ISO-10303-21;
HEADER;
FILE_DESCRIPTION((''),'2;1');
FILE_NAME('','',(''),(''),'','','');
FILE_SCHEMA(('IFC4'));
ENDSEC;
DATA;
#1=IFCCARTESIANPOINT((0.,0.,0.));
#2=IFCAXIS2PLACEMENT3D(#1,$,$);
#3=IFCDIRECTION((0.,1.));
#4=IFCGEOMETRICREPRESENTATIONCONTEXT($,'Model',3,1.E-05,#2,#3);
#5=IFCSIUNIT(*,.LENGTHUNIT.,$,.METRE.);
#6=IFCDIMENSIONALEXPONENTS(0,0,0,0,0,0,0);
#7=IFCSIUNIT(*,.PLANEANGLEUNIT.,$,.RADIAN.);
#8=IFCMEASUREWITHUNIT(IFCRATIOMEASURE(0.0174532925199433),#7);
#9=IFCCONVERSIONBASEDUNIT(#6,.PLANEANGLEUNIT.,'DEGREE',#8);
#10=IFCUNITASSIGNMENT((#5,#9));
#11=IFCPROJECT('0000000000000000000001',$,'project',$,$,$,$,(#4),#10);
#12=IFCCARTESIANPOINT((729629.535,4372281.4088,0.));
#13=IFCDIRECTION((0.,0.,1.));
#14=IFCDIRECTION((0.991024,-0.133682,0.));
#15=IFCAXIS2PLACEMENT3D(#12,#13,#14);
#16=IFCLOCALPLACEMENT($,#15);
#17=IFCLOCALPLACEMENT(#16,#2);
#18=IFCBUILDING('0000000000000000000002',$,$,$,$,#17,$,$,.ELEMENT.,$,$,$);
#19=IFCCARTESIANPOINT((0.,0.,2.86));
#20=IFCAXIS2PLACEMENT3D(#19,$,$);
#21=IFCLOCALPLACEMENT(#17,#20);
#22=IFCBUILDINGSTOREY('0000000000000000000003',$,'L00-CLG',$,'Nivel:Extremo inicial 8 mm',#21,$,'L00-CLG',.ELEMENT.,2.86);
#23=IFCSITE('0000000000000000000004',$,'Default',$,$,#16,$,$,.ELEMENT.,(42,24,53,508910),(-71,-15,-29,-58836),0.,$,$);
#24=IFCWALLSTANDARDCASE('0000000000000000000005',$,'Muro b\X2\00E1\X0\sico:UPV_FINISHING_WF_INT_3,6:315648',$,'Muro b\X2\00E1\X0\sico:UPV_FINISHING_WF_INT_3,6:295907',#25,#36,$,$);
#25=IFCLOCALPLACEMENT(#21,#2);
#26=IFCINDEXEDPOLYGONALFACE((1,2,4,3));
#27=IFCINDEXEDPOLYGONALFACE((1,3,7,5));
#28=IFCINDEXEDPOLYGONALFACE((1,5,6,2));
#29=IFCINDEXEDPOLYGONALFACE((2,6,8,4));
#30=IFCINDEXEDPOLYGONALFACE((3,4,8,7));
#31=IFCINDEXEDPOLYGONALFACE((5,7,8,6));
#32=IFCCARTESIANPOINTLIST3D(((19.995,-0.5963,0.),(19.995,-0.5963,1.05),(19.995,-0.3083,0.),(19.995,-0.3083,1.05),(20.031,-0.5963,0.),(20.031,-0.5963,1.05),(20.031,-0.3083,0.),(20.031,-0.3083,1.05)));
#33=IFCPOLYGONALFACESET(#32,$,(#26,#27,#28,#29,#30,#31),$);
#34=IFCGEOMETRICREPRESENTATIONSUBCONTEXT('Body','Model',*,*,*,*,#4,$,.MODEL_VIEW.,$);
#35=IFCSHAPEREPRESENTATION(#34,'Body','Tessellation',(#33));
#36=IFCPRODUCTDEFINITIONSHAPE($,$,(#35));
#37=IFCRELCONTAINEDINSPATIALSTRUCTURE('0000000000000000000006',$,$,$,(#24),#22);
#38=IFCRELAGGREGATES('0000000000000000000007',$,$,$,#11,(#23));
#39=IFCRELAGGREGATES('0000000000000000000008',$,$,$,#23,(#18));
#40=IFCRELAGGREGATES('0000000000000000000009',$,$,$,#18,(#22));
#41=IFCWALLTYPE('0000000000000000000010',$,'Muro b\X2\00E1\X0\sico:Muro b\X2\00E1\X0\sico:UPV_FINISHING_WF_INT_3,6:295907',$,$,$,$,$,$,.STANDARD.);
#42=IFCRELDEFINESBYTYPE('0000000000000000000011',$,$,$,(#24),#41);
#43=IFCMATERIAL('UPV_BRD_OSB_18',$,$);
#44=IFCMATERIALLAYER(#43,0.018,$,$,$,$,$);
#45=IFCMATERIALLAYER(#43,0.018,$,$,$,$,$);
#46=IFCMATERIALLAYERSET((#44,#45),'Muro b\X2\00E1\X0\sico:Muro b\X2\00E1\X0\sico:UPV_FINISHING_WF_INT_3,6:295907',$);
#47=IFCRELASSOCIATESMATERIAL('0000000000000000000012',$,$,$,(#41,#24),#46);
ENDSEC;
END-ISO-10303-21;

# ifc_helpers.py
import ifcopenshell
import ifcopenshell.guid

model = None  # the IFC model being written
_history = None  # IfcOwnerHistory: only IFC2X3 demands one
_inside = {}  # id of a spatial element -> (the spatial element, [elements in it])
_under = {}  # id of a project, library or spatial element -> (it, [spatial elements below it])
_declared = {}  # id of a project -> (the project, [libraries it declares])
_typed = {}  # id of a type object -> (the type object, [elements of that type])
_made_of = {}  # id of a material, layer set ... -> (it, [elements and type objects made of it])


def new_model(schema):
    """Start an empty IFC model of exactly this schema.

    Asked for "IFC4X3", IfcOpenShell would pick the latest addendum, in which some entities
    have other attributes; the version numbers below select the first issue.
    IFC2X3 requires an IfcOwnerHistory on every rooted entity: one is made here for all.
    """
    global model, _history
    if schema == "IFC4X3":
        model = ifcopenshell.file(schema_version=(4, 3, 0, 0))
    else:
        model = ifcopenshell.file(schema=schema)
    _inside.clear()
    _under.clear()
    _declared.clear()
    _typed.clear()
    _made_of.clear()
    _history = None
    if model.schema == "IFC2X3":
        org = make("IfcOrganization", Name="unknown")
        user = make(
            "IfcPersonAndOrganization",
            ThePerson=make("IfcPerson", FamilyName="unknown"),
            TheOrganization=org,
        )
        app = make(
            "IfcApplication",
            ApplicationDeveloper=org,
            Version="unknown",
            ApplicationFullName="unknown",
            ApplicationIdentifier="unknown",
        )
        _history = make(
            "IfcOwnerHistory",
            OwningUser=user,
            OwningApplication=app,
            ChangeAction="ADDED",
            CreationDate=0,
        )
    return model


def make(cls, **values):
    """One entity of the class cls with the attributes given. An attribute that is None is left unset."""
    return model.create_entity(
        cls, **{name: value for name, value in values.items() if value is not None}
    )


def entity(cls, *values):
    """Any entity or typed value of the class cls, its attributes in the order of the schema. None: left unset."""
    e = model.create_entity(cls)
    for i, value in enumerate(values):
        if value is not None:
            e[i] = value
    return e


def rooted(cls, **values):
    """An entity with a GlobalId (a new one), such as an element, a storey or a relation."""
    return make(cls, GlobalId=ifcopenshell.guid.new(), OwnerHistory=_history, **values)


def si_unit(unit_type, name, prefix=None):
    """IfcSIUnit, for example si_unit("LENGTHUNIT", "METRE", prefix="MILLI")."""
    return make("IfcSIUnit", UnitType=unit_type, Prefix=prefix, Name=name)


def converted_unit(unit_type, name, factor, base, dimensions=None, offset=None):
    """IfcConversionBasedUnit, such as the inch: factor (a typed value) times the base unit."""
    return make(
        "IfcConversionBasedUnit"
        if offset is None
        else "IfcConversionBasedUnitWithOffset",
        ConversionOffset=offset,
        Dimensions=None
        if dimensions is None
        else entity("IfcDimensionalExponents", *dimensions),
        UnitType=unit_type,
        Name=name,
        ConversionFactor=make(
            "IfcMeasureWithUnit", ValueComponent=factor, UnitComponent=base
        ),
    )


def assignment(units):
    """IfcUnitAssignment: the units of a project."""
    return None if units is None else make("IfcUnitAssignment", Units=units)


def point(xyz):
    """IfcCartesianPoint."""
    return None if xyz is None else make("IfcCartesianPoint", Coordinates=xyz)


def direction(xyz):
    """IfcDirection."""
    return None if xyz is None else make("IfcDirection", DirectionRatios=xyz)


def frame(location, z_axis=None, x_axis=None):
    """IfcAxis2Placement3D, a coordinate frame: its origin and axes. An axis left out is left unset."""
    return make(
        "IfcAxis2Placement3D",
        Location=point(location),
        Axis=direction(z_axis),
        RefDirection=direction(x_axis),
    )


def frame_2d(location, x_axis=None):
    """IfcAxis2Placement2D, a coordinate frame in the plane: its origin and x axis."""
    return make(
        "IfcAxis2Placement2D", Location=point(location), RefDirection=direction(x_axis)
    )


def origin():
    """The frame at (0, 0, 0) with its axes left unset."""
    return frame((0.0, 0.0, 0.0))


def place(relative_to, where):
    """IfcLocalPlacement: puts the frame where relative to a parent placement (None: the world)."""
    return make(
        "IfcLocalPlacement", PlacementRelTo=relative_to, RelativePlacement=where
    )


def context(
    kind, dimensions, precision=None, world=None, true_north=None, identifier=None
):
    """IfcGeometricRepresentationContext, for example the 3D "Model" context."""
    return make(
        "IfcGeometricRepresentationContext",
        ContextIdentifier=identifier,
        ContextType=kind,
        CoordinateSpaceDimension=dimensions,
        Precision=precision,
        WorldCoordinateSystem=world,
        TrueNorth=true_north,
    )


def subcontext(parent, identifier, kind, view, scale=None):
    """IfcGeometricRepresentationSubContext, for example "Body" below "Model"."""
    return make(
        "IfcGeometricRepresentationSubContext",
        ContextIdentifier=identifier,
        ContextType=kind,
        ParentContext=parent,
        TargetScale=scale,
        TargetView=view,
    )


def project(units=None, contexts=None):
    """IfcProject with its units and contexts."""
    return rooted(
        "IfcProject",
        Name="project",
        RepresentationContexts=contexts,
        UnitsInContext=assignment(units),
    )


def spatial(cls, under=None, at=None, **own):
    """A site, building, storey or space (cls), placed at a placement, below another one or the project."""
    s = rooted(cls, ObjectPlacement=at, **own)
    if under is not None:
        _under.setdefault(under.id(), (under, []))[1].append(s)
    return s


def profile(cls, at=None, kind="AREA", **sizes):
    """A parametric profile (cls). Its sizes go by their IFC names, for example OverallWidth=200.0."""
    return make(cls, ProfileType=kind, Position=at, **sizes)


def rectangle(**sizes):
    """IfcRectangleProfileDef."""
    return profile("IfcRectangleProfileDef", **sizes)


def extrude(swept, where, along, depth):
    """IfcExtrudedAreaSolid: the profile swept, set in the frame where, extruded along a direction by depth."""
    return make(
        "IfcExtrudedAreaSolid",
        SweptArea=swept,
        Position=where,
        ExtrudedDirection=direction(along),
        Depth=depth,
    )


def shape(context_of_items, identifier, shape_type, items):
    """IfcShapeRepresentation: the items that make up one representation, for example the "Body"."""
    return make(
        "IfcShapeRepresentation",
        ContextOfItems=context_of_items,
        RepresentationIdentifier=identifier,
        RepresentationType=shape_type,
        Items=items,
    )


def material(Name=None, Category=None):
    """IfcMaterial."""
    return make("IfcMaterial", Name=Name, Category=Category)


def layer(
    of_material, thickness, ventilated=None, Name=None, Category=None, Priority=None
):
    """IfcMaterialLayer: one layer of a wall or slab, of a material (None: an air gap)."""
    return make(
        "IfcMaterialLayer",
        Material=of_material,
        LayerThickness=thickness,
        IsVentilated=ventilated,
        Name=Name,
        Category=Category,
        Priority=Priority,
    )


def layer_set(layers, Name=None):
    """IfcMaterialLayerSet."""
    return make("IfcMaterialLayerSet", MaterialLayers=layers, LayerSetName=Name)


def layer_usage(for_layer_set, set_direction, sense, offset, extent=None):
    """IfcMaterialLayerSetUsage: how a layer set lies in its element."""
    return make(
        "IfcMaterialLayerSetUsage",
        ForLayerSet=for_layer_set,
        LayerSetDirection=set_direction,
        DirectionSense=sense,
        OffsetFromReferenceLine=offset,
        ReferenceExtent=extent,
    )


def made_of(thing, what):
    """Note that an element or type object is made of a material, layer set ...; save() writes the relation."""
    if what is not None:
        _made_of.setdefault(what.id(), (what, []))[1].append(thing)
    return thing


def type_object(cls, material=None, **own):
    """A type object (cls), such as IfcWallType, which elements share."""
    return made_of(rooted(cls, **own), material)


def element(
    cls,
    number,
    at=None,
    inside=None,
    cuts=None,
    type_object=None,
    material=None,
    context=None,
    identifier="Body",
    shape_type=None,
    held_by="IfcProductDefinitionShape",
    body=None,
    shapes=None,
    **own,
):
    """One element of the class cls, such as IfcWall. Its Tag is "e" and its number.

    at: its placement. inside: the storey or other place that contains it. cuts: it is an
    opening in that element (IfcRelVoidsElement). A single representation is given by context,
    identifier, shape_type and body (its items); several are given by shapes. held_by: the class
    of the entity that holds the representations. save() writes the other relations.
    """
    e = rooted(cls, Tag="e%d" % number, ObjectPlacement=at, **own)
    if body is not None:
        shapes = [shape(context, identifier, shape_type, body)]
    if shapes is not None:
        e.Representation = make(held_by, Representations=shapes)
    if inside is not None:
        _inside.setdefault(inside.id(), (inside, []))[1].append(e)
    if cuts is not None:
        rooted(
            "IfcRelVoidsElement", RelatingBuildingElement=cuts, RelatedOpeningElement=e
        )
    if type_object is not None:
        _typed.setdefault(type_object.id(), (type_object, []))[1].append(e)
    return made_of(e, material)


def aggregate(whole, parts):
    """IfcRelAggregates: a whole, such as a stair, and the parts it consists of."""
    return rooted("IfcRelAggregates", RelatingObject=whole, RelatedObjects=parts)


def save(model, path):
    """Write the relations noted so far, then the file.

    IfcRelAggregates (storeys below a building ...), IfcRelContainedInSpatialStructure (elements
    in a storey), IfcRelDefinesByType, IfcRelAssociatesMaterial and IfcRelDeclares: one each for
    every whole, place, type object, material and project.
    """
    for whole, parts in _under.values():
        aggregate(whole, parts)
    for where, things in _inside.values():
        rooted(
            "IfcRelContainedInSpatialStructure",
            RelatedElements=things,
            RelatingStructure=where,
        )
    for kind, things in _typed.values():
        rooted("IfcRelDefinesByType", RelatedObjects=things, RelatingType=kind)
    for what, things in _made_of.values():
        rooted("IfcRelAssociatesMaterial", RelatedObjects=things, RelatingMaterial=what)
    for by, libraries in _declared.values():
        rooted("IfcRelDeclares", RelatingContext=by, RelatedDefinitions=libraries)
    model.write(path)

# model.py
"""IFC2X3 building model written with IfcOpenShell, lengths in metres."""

from ifc_helpers import new_model, entity, si_unit, converted_unit, direction, frame, frame_2d, origin, place, context, subcontext, project, spatial, rectangle, extrude, material, layer, layer_set, layer_usage, type_object, element, save


model = new_model("IFC2X3")

# Units and contexts
model_context = context("Model", 3, precision=1e-05, world=origin(), true_north=direction((0.0, 1.0)))
body_context = subcontext(model_context, "Body", "Model", "MODEL_VIEW")
ifc_project = project(units=[si_unit("LENGTHUNIT", "METRE"), converted_unit("PLANEANGLEUNIT", "DEGREE", entity("IfcRatioMeasure", 0.0174532925199433), si_unit("PLANEANGLEUNIT", "RADIAN"), dimensions=[0, 0, 0, 0, 0, 0, 0])], contexts=[model_context])

# Site, building, storey
site_placement = place(None, frame((729629.535, 4372281.4088, 0.0), z_axis=(0.0, 0.0, 1.0), x_axis=(0.991024, -0.133682, 0.0)))
site = spatial("IfcSite", under=ifc_project, at=site_placement, Name="Default", CompositionType="ELEMENT", RefLatitude=(42, 24, 53, 508910), RefLongitude=(-71, -15, -29, -58836), RefElevation=0.0)
building_placement = place(site_placement, origin())
building = spatial("IfcBuilding", under=site, at=building_placement, CompositionType="ELEMENT")
storey_placement = place(building_placement, frame((0.0, 0.0, 2.86)))
storey = spatial("IfcBuildingStorey", under=building, at=storey_placement, Name="L00-CLG", ObjectType="Nivel:Extremo inicial 8 mm", LongName="L00-CLG", CompositionType="ELEMENT", Elevation=2.86)

# Wall
ifc_material_1 = material(Name="UPV_BRD_OSB_18")
ifc_layer_1 = layer(ifc_material_1, 0.018)
ifc_layer_2 = layer(ifc_material_1, 0.018)
ifc_layer_set_1 = layer_set([ifc_layer_1, ifc_layer_2], Name="Muro básico:Muro básico:UPV_FINISHING_WF_INT_3,6:295907")
wall_type_1 = type_object("IfcWallType", Name="Muro básico:Muro básico:UPV_FINISHING_WF_INT_3,6:295907", PredefinedType="STANDARD", material=ifc_layer_set_1)
ifc_layer_usage_1 = layer_usage(ifc_layer_set_1, "AXIS2", "NEGATIVE", 0.018)
wall_1_placement = place(storey_placement, frame((20.013, -0.5963, 0.0), z_axis=(0.0, 0.0, 1.0), x_axis=(0.0, 1.0, 0.0)))
element("IfcWallStandardCase", 1, at=wall_1_placement, inside=storey, type_object=wall_type_1, material=ifc_layer_usage_1, Name="Muro básico:UPV_FINISHING_WF_INT_3,6:315648", ObjectType="Muro básico:UPV_FINISHING_WF_INT_3,6:295907", context=body_context, shape_type="SweptSolid", body=[
    extrude(rectangle(XDim=0.288, YDim=0.036, at=frame_2d((0.144, 0.0), x_axis=(-1.0, 0.0))), origin(), (0.0, 0.0, 1.0), 1.05),
])

save(model, "model.ifc")
